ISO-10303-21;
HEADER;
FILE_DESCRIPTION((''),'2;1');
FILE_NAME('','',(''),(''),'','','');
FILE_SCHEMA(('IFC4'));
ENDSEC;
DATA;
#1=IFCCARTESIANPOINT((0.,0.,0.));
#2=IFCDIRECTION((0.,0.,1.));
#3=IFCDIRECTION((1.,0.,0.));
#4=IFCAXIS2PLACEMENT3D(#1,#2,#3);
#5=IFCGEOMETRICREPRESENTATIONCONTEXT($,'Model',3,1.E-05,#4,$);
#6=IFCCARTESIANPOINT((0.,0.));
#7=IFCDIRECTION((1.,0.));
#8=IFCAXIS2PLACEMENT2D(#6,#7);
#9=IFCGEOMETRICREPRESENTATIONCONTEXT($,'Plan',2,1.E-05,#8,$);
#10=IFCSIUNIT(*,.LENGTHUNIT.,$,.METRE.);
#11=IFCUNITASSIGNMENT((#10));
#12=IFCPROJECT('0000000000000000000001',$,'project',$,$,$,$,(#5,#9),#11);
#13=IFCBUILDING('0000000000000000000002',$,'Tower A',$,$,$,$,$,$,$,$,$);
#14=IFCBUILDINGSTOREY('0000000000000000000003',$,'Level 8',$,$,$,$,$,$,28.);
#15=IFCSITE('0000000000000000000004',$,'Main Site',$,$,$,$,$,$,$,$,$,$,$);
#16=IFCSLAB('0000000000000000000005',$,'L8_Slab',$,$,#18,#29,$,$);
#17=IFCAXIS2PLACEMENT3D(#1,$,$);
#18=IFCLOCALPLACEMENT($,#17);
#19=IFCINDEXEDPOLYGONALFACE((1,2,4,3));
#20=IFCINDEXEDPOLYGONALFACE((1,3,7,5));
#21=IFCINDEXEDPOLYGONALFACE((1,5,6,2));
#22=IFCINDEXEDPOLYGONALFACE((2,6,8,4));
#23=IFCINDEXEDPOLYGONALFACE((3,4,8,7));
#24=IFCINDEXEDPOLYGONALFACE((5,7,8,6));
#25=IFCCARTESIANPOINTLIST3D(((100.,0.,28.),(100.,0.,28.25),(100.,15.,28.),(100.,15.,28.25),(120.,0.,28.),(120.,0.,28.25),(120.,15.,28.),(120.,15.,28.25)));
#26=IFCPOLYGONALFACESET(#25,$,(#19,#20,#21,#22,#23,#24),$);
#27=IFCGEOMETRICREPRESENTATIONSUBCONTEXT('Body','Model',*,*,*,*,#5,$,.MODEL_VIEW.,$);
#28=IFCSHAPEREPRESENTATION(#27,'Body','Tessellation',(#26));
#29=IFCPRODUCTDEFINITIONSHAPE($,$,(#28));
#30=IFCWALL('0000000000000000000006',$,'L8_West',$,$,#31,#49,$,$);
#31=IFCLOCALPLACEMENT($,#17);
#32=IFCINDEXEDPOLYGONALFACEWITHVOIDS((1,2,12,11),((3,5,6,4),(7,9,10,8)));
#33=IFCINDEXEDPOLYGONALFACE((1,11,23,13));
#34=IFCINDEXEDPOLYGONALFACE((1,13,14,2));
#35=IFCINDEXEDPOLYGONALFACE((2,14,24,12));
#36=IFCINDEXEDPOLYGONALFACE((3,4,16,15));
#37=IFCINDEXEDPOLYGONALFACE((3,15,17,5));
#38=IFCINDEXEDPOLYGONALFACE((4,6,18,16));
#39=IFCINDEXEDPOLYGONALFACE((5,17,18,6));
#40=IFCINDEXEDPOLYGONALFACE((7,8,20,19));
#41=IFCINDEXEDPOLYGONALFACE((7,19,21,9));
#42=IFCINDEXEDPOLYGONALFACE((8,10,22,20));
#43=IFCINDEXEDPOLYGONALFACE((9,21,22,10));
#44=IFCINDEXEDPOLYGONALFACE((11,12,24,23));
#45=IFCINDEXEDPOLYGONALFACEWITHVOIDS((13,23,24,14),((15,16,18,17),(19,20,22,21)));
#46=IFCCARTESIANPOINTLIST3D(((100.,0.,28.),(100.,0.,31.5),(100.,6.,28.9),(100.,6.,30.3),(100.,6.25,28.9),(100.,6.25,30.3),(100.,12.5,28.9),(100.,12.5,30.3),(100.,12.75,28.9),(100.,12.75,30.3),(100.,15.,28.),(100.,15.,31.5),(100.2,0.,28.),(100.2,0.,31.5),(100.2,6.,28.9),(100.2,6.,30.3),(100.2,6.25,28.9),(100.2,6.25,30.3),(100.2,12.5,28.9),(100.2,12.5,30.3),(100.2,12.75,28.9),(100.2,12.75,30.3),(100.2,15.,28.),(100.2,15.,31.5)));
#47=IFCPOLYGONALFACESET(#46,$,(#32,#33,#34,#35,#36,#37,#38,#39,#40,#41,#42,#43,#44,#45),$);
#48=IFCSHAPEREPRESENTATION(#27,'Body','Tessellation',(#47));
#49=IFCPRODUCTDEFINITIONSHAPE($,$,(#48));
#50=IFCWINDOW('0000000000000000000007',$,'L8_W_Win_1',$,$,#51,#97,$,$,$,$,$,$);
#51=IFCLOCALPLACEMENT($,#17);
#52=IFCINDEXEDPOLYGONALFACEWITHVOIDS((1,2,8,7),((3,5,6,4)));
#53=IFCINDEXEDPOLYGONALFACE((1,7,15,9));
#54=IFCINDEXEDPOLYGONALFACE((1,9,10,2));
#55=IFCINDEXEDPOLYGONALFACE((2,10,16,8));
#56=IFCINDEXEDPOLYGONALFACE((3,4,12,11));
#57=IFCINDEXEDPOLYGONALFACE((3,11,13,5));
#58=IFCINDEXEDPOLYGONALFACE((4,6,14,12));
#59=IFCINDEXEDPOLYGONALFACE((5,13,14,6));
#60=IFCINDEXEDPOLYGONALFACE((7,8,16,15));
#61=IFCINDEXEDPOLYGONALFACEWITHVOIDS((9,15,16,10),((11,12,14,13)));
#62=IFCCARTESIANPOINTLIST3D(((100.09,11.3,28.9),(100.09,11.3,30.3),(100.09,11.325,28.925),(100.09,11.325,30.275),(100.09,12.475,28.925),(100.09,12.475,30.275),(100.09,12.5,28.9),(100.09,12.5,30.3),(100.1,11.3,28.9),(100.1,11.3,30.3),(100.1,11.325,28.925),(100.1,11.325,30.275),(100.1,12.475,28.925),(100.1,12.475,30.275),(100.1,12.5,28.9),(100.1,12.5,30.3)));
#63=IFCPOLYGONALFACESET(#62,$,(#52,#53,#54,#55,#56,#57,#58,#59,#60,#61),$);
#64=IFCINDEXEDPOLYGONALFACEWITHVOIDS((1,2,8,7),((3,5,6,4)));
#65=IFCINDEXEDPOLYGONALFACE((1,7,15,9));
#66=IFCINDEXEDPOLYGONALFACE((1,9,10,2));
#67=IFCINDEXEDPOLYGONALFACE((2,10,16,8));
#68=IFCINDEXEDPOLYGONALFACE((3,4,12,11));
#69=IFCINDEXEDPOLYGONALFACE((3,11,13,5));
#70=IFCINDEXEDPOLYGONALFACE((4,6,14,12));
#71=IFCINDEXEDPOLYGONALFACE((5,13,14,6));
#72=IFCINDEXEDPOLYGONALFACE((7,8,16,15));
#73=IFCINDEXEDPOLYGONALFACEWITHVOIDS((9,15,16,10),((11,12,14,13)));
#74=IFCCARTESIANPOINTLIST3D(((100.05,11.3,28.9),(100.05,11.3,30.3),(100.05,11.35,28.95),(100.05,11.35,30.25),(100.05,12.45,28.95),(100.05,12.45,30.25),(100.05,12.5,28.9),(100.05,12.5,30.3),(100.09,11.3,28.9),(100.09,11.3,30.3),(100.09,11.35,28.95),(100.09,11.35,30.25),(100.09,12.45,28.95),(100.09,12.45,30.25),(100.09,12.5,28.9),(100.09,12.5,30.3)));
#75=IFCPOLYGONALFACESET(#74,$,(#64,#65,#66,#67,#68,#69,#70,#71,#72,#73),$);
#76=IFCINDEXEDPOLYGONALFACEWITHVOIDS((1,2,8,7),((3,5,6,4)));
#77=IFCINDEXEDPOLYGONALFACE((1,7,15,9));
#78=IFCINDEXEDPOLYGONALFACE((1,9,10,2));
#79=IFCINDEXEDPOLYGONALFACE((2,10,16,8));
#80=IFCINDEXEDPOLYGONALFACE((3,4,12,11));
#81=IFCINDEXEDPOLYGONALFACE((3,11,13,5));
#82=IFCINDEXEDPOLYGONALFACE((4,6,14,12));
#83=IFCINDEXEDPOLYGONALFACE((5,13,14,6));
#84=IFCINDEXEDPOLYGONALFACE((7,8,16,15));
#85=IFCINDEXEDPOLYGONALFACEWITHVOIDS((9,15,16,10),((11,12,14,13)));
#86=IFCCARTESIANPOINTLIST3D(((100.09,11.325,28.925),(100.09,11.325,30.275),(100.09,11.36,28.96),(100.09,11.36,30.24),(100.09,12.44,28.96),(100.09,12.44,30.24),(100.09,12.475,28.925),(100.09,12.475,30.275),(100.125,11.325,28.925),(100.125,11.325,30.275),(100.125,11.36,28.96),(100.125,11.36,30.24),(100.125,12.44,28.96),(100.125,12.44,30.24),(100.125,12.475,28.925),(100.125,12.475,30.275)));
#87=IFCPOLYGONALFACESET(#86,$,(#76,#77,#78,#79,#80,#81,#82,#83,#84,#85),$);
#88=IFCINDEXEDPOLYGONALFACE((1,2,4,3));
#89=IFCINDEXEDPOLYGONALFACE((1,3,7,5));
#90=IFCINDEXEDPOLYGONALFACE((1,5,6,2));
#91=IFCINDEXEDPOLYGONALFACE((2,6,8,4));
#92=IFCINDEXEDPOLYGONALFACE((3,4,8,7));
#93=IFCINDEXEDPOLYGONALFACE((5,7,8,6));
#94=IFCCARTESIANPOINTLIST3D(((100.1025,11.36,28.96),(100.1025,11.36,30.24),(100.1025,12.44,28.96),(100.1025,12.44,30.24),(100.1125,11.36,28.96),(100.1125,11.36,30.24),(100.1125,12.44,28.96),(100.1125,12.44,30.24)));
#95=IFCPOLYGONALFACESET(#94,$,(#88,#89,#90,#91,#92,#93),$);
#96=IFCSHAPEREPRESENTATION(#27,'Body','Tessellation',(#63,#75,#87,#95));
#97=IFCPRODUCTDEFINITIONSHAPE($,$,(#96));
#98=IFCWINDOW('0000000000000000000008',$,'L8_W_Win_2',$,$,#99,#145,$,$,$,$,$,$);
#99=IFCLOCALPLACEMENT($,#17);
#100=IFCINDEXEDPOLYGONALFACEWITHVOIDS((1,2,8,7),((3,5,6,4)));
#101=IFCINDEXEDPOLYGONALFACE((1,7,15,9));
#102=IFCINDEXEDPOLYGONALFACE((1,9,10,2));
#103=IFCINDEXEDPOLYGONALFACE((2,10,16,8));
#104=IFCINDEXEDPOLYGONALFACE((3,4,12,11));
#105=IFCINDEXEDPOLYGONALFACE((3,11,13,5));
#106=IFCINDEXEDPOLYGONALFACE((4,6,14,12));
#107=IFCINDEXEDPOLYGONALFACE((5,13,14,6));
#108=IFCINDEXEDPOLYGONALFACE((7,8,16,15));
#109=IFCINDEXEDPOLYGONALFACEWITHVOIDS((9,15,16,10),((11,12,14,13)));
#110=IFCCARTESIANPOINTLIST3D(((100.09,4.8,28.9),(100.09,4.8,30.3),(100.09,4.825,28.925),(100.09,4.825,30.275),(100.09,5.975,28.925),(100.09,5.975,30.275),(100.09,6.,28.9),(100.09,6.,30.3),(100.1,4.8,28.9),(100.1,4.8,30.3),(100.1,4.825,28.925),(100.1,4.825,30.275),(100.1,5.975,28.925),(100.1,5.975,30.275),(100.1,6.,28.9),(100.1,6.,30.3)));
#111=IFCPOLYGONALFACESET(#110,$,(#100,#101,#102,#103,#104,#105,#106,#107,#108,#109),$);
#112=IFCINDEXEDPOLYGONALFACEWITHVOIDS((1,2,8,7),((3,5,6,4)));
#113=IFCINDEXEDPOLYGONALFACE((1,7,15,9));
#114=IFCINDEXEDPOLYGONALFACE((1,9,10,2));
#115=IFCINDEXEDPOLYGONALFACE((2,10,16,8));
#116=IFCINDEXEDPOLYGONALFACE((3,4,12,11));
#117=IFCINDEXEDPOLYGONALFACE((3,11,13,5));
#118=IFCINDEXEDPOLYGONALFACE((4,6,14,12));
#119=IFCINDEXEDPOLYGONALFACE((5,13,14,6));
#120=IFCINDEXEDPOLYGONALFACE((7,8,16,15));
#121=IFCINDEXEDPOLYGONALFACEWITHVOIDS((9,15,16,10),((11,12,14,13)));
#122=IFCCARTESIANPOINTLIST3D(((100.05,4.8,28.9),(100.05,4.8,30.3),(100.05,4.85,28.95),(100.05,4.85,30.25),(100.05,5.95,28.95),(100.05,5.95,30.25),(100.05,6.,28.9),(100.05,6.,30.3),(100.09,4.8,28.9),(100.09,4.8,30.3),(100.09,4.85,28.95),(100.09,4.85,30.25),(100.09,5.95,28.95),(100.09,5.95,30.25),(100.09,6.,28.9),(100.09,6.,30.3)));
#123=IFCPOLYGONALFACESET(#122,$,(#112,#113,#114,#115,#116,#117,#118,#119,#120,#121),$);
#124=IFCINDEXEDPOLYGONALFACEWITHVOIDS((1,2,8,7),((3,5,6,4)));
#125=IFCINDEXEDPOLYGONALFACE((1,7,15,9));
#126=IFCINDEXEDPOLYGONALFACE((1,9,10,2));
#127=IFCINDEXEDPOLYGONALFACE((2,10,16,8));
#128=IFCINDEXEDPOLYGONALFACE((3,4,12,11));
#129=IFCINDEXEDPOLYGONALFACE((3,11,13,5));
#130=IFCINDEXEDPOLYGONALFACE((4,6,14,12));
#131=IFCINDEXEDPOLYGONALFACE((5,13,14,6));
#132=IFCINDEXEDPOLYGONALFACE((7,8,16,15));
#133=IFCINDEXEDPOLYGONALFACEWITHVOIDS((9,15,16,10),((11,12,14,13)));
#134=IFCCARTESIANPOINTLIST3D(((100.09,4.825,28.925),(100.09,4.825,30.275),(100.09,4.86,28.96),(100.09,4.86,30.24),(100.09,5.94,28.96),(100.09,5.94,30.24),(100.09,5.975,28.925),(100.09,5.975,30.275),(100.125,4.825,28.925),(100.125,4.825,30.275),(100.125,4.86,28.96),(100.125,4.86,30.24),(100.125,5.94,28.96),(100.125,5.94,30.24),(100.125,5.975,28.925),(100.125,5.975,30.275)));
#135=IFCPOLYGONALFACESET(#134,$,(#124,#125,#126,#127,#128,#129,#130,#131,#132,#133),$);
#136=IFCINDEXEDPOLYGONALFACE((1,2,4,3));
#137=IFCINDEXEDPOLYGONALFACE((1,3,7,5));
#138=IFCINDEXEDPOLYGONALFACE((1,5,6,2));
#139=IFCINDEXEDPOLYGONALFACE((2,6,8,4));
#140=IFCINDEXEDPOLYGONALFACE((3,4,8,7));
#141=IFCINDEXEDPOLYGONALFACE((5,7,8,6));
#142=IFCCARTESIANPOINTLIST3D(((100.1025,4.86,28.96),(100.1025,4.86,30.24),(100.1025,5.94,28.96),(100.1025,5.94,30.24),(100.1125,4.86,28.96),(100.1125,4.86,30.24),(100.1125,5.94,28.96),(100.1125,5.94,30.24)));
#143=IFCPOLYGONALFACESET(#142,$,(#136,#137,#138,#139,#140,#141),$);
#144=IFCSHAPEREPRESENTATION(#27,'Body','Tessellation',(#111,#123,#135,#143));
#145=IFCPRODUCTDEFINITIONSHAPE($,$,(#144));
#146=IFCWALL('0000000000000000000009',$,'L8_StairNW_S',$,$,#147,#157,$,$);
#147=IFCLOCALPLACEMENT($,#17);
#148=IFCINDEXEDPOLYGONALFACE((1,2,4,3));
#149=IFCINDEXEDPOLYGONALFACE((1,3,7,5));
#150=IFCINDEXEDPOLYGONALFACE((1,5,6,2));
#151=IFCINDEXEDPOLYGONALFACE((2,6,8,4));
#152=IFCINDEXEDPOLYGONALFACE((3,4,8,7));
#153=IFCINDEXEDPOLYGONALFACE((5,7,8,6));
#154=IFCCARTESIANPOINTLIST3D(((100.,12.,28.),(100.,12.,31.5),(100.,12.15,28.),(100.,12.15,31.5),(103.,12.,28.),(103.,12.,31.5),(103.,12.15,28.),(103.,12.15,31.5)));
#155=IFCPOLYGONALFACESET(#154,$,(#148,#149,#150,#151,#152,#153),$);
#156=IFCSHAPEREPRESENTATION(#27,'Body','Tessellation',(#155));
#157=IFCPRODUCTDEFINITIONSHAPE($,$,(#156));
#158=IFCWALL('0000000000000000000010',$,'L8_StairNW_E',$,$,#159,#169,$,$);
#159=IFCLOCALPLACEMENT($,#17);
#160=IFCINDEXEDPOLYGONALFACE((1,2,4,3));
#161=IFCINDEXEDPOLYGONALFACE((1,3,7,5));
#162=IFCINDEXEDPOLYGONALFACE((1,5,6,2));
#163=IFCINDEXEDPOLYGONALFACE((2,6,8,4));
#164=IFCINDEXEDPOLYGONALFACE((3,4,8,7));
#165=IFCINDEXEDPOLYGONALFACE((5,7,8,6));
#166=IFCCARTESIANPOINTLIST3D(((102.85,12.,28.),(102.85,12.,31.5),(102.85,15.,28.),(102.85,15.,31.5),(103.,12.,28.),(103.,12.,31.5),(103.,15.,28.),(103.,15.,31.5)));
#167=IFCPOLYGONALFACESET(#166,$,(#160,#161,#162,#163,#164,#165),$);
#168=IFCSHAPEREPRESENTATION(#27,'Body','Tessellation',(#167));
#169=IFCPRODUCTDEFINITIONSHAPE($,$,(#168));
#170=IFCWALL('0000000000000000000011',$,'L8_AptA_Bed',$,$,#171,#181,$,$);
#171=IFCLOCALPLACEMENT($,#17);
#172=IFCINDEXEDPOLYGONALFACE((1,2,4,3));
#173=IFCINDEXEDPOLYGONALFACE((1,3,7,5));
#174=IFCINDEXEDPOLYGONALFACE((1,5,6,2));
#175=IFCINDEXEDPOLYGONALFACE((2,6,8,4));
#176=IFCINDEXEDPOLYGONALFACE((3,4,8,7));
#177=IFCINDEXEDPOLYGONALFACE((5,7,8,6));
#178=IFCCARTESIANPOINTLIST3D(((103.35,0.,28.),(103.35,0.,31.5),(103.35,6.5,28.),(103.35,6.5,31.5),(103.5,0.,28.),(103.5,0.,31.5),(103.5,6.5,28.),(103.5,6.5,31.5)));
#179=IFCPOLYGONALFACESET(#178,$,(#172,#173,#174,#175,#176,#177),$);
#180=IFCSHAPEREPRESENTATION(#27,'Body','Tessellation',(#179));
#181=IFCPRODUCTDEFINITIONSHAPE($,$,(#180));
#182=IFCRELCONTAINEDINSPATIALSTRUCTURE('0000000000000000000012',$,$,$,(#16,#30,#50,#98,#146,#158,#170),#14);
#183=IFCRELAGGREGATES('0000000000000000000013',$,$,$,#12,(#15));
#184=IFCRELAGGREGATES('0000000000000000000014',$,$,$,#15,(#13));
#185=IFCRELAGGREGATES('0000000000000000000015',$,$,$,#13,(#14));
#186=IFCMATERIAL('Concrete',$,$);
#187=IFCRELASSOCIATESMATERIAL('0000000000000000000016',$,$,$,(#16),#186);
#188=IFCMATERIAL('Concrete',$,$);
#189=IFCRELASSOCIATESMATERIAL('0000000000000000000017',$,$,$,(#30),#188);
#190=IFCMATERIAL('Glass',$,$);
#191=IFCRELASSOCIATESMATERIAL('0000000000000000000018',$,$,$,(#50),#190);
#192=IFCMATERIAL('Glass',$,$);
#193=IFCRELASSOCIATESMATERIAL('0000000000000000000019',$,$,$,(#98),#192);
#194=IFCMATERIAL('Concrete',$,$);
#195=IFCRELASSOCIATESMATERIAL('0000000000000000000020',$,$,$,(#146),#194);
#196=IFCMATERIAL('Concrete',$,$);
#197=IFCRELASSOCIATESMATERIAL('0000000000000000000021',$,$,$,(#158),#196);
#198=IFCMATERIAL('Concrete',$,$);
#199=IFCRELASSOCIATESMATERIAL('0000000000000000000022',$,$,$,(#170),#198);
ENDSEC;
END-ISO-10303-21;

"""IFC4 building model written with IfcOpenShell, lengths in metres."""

from ifc_helpers import new_model, si_unit, frame, origin_with_axes, origin_2d_with_axis, place, context, subcontext, project, spatial, line, indexed_curve, outline, extrude, material, element, fill, save


model = new_model("IFC4")

# Units and contexts
model_context = context("Model", 3, precision=1e-05, world=origin_with_axes())
plan_context = context("Plan", 2, precision=1e-05, world=origin_2d_with_axis())
body_context = subcontext(model_context, "Body", "Model", "MODEL_VIEW")
ifc_project = project(units=[si_unit("LENGTHUNIT", "METRE")], contexts=[model_context, plan_context])

# Site, building, storey
site = spatial("IfcSite", under=ifc_project, Name="Main Site")
building = spatial("IfcBuilding", under=site, Name="Tower A")
storey = spatial("IfcBuildingStorey", under=building, Name="Level 8", Elevation=28.0)

# Slab
ifc_material_1 = material(Name="Concrete")
slab_placement = place(None, frame((100.0, 0.0, 28.0), z_axis=(0.0, 0.0, 1.0), x_axis=(1.0, 0.0, 0.0)))
element("IfcSlab", 1, at=slab_placement, inside=storey, material=ifc_material_1, Name="L8_Slab", context=body_context, shape_type="SweptSolid", body=[
    extrude(outline(indexed_curve([(0.0, 0.0), (20.0, 0.0), (20.0, 15.0), (0.0, 15.0)])), None, (0.0, 0.0, 1.0), 0.25),
])

# Wall, openings, windows
ifc_material_2 = material(Name="Concrete")
wall_1_placement = place(None, frame((100.0, 15.0, 28.0), z_axis=(0.0, 0.0, 1.0), x_axis=(0.0, -1.0, 0.0)))
wall_1 = element("IfcWall", 2, at=wall_1_placement, inside=storey, material=ifc_material_2, Name="L8_West", context=body_context, shape_type="SweptSolid", body=[
    extrude(outline(indexed_curve([(0.0, 0.0), (0.0, 0.2), (15.0, 0.2), (15.0, 0.0), (0.0, 0.0)], self_intersect=False)), origin_with_axes(), (0.0, 0.0, 1.0), 3.5),
])
opening_1_placement = place(wall_1_placement, frame((2.5, 0.0, 0.9), z_axis=(0.0, 0.0, 1.0), x_axis=(0.0, 1.0, 0.0)))
opening_1 = element("IfcOpeningElement", 3, at=opening_1_placement, cuts=wall_1, context=body_context, shape_type="SweptSolid", body=[
    extrude(outline(indexed_curve([(0.0, 0.0), (0.0, 0.25), (1.2, 0.25), (1.2, 0.0), (0.0, 0.0)], self_intersect=False)), origin_with_axes(), (0.0, 0.0, 1.0), 1.4),
])
opening_2_placement = place(wall_1_placement, frame((9.0, 0.0, 0.9), z_axis=(0.0, 0.0, 1.0), x_axis=(0.0, 1.0, 0.0)))
opening_2 = element("IfcOpeningElement", 4, at=opening_2_placement, cuts=wall_1, context=body_context, shape_type="SweptSolid", body=[
    extrude(outline(indexed_curve([(0.0, 0.0), (0.0, 0.25), (1.2, 0.25), (1.2, 0.0), (0.0, 0.0)], self_intersect=False)), origin_with_axes(), (0.0, 0.0, 1.0), 1.4),
])
ifc_material_3 = material(Name="Glass")
window_1_placement = place(None, frame((100.0, 12.5, 28.9), z_axis=(0.0, 0.0, 1.0), x_axis=(0.0, -1.0, 0.0)))
window_1 = element("IfcWindow", 5, at=window_1_placement, inside=storey, material=ifc_material_3, Name="L8_W_Win_1", context=body_context, shape_type="SweptSolid", body=[
    extrude(outline(indexed_curve([(0.0, 0.0), (1.2, 0.0), (1.2, 1.4), (0.0, 1.4)], segments=[line(1, 2, 3, 4, 1)]), holes=[indexed_curve([(0.025, 0.025), (1.175, 0.025), (1.175, 1.375), (0.025, 1.375)], segments=[line(1, 2, 3, 4, 1)])]), frame((0.0, 0.09, 0.0), z_axis=(0.0, -1.0, 0.0), x_axis=(1.0, 0.0, 0.0)), (0.0, 0.0, -1.0), 0.01),
    extrude(outline(indexed_curve([(0.0, 0.0), (1.2, 0.0), (1.2, 1.4), (0.0, 1.4)], segments=[line(1, 2, 3, 4, 1)]), holes=[indexed_curve([(0.05, 0.05), (1.15, 0.05), (1.15, 1.35), (0.05, 1.35)], segments=[line(1, 2, 3, 4, 1)])]), frame((0.0, 0.05, 0.0), z_axis=(0.0, -1.0, 0.0), x_axis=(1.0, 0.0, 0.0)), (0.0, 0.0, -1.0), 0.04),
    extrude(outline(indexed_curve([(0.0, 0.0), (1.15, 0.0), (1.15, 1.35), (0.0, 1.35)], segments=[line(1, 2, 3, 4, 1)]), holes=[indexed_curve([(0.035, 0.035), (1.115, 0.035), (1.115, 1.315), (0.035, 1.315)], segments=[line(1, 2, 3, 4, 1)])]), frame((0.025, 0.09, 0.025), z_axis=(0.0, -1.0, 0.0), x_axis=(1.0, 0.0, 0.0)), (0.0, 0.0, -1.0), 0.035),
    extrude(outline(indexed_curve([(0.035, 0.035), (1.115, 0.035), (1.115, 1.315), (0.035, 1.315)], segments=[line(1, 2, 3, 4, 1)])), frame((0.025, 0.1025, 0.025), z_axis=(0.0, -1.0, 0.0), x_axis=(1.0, 0.0, 0.0)), (0.0, 0.0, -1.0), 0.01),
])
fill(opening_1, window_1)
ifc_material_4 = material(Name="Glass")
window_2_placement = place(None, frame((100.0, 6.0, 28.9), z_axis=(0.0, 0.0, 1.0), x_axis=(0.0, -1.0, 0.0)))
window_2 = element("IfcWindow", 6, at=window_2_placement, inside=storey, material=ifc_material_4, Name="L8_W_Win_2", context=body_context, shape_type="SweptSolid", body=[
    extrude(outline(indexed_curve([(0.0, 0.0), (1.2, 0.0), (1.2, 1.4), (0.0, 1.4)], segments=[line(1, 2, 3, 4, 1)]), holes=[indexed_curve([(0.025, 0.025), (1.175, 0.025), (1.175, 1.375), (0.025, 1.375)], segments=[line(1, 2, 3, 4, 1)])]), frame((0.0, 0.09, 0.0), z_axis=(0.0, -1.0, 0.0), x_axis=(1.0, 0.0, 0.0)), (0.0, 0.0, -1.0), 0.01),
    extrude(outline(indexed_curve([(0.0, 0.0), (1.2, 0.0), (1.2, 1.4), (0.0, 1.4)], segments=[line(1, 2, 3, 4, 1)]), holes=[indexed_curve([(0.05, 0.05), (1.15, 0.05), (1.15, 1.35), (0.05, 1.35)], segments=[line(1, 2, 3, 4, 1)])]), frame((0.0, 0.05, 0.0), z_axis=(0.0, -1.0, 0.0), x_axis=(1.0, 0.0, 0.0)), (0.0, 0.0, -1.0), 0.04),
    extrude(outline(indexed_curve([(0.0, 0.0), (1.15, 0.0), (1.15, 1.35), (0.0, 1.35)], segments=[line(1, 2, 3, 4, 1)]), holes=[indexed_curve([(0.035, 0.035), (1.115, 0.035), (1.115, 1.315), (0.035, 1.315)], segments=[line(1, 2, 3, 4, 1)])]), frame((0.025, 0.09, 0.025), z_axis=(0.0, -1.0, 0.0), x_axis=(1.0, 0.0, 0.0)), (0.0, 0.0, -1.0), 0.035),
    extrude(outline(indexed_curve([(0.035, 0.035), (1.115, 0.035), (1.115, 1.315), (0.035, 1.315)], segments=[line(1, 2, 3, 4, 1)])), frame((0.025, 0.1025, 0.025), z_axis=(0.0, -1.0, 0.0), x_axis=(1.0, 0.0, 0.0)), (0.0, 0.0, -1.0), 0.01),
])
fill(opening_2, window_2)

# Walls
ifc_material_5 = material(Name="Concrete")
wall_2_placement = place(None, frame((100.0, 12.0, 28.0), z_axis=(0.0, 0.0, 1.0), x_axis=(1.0, 0.0, 0.0)))
element("IfcWall", 7, at=wall_2_placement, inside=storey, material=ifc_material_5, Name="L8_StairNW_S", context=body_context, shape_type="SweptSolid", body=[
    extrude(outline(indexed_curve([(0.0, 0.0), (0.0, 0.15), (3.0, 0.15), (3.0, 0.0), (0.0, 0.0)], self_intersect=False)), origin_with_axes(), (0.0, 0.0, 1.0), 3.5),
])
ifc_material_6 = material(Name="Concrete")
wall_3_placement = place(None, frame((103.0, 12.0, 28.0), z_axis=(0.0, 0.0, 1.0), x_axis=(0.0, 1.0, 0.0)))
element("IfcWall", 8, at=wall_3_placement, inside=storey, material=ifc_material_6, Name="L8_StairNW_E", context=body_context, shape_type="SweptSolid", body=[
    extrude(outline(indexed_curve([(0.0, 0.0), (0.0, 0.15), (3.0, 0.15), (3.0, 0.0), (0.0, 0.0)], self_intersect=False)), origin_with_axes(), (0.0, 0.0, 1.0), 3.5),
])

# Wall
ifc_material_7 = material(Name="Concrete")
wall_4_placement = place(None, frame((103.5, 0.0, 28.0), z_axis=(0.0, 0.0, 1.0), x_axis=(0.0, 1.0, 0.0)))
element("IfcWall", 9, at=wall_4_placement, inside=storey, material=ifc_material_7, Name="L8_AptA_Bed", context=body_context, shape_type="SweptSolid", body=[
    extrude(outline(indexed_curve([(0.0, 0.0), (0.0, 0.15), (6.5, 0.15), (6.5, 0.0), (0.0, 0.0)], self_intersect=False)), origin_with_axes(), (0.0, 0.0, 1.0), 3.5),
])

save(model, "model.ifc")
